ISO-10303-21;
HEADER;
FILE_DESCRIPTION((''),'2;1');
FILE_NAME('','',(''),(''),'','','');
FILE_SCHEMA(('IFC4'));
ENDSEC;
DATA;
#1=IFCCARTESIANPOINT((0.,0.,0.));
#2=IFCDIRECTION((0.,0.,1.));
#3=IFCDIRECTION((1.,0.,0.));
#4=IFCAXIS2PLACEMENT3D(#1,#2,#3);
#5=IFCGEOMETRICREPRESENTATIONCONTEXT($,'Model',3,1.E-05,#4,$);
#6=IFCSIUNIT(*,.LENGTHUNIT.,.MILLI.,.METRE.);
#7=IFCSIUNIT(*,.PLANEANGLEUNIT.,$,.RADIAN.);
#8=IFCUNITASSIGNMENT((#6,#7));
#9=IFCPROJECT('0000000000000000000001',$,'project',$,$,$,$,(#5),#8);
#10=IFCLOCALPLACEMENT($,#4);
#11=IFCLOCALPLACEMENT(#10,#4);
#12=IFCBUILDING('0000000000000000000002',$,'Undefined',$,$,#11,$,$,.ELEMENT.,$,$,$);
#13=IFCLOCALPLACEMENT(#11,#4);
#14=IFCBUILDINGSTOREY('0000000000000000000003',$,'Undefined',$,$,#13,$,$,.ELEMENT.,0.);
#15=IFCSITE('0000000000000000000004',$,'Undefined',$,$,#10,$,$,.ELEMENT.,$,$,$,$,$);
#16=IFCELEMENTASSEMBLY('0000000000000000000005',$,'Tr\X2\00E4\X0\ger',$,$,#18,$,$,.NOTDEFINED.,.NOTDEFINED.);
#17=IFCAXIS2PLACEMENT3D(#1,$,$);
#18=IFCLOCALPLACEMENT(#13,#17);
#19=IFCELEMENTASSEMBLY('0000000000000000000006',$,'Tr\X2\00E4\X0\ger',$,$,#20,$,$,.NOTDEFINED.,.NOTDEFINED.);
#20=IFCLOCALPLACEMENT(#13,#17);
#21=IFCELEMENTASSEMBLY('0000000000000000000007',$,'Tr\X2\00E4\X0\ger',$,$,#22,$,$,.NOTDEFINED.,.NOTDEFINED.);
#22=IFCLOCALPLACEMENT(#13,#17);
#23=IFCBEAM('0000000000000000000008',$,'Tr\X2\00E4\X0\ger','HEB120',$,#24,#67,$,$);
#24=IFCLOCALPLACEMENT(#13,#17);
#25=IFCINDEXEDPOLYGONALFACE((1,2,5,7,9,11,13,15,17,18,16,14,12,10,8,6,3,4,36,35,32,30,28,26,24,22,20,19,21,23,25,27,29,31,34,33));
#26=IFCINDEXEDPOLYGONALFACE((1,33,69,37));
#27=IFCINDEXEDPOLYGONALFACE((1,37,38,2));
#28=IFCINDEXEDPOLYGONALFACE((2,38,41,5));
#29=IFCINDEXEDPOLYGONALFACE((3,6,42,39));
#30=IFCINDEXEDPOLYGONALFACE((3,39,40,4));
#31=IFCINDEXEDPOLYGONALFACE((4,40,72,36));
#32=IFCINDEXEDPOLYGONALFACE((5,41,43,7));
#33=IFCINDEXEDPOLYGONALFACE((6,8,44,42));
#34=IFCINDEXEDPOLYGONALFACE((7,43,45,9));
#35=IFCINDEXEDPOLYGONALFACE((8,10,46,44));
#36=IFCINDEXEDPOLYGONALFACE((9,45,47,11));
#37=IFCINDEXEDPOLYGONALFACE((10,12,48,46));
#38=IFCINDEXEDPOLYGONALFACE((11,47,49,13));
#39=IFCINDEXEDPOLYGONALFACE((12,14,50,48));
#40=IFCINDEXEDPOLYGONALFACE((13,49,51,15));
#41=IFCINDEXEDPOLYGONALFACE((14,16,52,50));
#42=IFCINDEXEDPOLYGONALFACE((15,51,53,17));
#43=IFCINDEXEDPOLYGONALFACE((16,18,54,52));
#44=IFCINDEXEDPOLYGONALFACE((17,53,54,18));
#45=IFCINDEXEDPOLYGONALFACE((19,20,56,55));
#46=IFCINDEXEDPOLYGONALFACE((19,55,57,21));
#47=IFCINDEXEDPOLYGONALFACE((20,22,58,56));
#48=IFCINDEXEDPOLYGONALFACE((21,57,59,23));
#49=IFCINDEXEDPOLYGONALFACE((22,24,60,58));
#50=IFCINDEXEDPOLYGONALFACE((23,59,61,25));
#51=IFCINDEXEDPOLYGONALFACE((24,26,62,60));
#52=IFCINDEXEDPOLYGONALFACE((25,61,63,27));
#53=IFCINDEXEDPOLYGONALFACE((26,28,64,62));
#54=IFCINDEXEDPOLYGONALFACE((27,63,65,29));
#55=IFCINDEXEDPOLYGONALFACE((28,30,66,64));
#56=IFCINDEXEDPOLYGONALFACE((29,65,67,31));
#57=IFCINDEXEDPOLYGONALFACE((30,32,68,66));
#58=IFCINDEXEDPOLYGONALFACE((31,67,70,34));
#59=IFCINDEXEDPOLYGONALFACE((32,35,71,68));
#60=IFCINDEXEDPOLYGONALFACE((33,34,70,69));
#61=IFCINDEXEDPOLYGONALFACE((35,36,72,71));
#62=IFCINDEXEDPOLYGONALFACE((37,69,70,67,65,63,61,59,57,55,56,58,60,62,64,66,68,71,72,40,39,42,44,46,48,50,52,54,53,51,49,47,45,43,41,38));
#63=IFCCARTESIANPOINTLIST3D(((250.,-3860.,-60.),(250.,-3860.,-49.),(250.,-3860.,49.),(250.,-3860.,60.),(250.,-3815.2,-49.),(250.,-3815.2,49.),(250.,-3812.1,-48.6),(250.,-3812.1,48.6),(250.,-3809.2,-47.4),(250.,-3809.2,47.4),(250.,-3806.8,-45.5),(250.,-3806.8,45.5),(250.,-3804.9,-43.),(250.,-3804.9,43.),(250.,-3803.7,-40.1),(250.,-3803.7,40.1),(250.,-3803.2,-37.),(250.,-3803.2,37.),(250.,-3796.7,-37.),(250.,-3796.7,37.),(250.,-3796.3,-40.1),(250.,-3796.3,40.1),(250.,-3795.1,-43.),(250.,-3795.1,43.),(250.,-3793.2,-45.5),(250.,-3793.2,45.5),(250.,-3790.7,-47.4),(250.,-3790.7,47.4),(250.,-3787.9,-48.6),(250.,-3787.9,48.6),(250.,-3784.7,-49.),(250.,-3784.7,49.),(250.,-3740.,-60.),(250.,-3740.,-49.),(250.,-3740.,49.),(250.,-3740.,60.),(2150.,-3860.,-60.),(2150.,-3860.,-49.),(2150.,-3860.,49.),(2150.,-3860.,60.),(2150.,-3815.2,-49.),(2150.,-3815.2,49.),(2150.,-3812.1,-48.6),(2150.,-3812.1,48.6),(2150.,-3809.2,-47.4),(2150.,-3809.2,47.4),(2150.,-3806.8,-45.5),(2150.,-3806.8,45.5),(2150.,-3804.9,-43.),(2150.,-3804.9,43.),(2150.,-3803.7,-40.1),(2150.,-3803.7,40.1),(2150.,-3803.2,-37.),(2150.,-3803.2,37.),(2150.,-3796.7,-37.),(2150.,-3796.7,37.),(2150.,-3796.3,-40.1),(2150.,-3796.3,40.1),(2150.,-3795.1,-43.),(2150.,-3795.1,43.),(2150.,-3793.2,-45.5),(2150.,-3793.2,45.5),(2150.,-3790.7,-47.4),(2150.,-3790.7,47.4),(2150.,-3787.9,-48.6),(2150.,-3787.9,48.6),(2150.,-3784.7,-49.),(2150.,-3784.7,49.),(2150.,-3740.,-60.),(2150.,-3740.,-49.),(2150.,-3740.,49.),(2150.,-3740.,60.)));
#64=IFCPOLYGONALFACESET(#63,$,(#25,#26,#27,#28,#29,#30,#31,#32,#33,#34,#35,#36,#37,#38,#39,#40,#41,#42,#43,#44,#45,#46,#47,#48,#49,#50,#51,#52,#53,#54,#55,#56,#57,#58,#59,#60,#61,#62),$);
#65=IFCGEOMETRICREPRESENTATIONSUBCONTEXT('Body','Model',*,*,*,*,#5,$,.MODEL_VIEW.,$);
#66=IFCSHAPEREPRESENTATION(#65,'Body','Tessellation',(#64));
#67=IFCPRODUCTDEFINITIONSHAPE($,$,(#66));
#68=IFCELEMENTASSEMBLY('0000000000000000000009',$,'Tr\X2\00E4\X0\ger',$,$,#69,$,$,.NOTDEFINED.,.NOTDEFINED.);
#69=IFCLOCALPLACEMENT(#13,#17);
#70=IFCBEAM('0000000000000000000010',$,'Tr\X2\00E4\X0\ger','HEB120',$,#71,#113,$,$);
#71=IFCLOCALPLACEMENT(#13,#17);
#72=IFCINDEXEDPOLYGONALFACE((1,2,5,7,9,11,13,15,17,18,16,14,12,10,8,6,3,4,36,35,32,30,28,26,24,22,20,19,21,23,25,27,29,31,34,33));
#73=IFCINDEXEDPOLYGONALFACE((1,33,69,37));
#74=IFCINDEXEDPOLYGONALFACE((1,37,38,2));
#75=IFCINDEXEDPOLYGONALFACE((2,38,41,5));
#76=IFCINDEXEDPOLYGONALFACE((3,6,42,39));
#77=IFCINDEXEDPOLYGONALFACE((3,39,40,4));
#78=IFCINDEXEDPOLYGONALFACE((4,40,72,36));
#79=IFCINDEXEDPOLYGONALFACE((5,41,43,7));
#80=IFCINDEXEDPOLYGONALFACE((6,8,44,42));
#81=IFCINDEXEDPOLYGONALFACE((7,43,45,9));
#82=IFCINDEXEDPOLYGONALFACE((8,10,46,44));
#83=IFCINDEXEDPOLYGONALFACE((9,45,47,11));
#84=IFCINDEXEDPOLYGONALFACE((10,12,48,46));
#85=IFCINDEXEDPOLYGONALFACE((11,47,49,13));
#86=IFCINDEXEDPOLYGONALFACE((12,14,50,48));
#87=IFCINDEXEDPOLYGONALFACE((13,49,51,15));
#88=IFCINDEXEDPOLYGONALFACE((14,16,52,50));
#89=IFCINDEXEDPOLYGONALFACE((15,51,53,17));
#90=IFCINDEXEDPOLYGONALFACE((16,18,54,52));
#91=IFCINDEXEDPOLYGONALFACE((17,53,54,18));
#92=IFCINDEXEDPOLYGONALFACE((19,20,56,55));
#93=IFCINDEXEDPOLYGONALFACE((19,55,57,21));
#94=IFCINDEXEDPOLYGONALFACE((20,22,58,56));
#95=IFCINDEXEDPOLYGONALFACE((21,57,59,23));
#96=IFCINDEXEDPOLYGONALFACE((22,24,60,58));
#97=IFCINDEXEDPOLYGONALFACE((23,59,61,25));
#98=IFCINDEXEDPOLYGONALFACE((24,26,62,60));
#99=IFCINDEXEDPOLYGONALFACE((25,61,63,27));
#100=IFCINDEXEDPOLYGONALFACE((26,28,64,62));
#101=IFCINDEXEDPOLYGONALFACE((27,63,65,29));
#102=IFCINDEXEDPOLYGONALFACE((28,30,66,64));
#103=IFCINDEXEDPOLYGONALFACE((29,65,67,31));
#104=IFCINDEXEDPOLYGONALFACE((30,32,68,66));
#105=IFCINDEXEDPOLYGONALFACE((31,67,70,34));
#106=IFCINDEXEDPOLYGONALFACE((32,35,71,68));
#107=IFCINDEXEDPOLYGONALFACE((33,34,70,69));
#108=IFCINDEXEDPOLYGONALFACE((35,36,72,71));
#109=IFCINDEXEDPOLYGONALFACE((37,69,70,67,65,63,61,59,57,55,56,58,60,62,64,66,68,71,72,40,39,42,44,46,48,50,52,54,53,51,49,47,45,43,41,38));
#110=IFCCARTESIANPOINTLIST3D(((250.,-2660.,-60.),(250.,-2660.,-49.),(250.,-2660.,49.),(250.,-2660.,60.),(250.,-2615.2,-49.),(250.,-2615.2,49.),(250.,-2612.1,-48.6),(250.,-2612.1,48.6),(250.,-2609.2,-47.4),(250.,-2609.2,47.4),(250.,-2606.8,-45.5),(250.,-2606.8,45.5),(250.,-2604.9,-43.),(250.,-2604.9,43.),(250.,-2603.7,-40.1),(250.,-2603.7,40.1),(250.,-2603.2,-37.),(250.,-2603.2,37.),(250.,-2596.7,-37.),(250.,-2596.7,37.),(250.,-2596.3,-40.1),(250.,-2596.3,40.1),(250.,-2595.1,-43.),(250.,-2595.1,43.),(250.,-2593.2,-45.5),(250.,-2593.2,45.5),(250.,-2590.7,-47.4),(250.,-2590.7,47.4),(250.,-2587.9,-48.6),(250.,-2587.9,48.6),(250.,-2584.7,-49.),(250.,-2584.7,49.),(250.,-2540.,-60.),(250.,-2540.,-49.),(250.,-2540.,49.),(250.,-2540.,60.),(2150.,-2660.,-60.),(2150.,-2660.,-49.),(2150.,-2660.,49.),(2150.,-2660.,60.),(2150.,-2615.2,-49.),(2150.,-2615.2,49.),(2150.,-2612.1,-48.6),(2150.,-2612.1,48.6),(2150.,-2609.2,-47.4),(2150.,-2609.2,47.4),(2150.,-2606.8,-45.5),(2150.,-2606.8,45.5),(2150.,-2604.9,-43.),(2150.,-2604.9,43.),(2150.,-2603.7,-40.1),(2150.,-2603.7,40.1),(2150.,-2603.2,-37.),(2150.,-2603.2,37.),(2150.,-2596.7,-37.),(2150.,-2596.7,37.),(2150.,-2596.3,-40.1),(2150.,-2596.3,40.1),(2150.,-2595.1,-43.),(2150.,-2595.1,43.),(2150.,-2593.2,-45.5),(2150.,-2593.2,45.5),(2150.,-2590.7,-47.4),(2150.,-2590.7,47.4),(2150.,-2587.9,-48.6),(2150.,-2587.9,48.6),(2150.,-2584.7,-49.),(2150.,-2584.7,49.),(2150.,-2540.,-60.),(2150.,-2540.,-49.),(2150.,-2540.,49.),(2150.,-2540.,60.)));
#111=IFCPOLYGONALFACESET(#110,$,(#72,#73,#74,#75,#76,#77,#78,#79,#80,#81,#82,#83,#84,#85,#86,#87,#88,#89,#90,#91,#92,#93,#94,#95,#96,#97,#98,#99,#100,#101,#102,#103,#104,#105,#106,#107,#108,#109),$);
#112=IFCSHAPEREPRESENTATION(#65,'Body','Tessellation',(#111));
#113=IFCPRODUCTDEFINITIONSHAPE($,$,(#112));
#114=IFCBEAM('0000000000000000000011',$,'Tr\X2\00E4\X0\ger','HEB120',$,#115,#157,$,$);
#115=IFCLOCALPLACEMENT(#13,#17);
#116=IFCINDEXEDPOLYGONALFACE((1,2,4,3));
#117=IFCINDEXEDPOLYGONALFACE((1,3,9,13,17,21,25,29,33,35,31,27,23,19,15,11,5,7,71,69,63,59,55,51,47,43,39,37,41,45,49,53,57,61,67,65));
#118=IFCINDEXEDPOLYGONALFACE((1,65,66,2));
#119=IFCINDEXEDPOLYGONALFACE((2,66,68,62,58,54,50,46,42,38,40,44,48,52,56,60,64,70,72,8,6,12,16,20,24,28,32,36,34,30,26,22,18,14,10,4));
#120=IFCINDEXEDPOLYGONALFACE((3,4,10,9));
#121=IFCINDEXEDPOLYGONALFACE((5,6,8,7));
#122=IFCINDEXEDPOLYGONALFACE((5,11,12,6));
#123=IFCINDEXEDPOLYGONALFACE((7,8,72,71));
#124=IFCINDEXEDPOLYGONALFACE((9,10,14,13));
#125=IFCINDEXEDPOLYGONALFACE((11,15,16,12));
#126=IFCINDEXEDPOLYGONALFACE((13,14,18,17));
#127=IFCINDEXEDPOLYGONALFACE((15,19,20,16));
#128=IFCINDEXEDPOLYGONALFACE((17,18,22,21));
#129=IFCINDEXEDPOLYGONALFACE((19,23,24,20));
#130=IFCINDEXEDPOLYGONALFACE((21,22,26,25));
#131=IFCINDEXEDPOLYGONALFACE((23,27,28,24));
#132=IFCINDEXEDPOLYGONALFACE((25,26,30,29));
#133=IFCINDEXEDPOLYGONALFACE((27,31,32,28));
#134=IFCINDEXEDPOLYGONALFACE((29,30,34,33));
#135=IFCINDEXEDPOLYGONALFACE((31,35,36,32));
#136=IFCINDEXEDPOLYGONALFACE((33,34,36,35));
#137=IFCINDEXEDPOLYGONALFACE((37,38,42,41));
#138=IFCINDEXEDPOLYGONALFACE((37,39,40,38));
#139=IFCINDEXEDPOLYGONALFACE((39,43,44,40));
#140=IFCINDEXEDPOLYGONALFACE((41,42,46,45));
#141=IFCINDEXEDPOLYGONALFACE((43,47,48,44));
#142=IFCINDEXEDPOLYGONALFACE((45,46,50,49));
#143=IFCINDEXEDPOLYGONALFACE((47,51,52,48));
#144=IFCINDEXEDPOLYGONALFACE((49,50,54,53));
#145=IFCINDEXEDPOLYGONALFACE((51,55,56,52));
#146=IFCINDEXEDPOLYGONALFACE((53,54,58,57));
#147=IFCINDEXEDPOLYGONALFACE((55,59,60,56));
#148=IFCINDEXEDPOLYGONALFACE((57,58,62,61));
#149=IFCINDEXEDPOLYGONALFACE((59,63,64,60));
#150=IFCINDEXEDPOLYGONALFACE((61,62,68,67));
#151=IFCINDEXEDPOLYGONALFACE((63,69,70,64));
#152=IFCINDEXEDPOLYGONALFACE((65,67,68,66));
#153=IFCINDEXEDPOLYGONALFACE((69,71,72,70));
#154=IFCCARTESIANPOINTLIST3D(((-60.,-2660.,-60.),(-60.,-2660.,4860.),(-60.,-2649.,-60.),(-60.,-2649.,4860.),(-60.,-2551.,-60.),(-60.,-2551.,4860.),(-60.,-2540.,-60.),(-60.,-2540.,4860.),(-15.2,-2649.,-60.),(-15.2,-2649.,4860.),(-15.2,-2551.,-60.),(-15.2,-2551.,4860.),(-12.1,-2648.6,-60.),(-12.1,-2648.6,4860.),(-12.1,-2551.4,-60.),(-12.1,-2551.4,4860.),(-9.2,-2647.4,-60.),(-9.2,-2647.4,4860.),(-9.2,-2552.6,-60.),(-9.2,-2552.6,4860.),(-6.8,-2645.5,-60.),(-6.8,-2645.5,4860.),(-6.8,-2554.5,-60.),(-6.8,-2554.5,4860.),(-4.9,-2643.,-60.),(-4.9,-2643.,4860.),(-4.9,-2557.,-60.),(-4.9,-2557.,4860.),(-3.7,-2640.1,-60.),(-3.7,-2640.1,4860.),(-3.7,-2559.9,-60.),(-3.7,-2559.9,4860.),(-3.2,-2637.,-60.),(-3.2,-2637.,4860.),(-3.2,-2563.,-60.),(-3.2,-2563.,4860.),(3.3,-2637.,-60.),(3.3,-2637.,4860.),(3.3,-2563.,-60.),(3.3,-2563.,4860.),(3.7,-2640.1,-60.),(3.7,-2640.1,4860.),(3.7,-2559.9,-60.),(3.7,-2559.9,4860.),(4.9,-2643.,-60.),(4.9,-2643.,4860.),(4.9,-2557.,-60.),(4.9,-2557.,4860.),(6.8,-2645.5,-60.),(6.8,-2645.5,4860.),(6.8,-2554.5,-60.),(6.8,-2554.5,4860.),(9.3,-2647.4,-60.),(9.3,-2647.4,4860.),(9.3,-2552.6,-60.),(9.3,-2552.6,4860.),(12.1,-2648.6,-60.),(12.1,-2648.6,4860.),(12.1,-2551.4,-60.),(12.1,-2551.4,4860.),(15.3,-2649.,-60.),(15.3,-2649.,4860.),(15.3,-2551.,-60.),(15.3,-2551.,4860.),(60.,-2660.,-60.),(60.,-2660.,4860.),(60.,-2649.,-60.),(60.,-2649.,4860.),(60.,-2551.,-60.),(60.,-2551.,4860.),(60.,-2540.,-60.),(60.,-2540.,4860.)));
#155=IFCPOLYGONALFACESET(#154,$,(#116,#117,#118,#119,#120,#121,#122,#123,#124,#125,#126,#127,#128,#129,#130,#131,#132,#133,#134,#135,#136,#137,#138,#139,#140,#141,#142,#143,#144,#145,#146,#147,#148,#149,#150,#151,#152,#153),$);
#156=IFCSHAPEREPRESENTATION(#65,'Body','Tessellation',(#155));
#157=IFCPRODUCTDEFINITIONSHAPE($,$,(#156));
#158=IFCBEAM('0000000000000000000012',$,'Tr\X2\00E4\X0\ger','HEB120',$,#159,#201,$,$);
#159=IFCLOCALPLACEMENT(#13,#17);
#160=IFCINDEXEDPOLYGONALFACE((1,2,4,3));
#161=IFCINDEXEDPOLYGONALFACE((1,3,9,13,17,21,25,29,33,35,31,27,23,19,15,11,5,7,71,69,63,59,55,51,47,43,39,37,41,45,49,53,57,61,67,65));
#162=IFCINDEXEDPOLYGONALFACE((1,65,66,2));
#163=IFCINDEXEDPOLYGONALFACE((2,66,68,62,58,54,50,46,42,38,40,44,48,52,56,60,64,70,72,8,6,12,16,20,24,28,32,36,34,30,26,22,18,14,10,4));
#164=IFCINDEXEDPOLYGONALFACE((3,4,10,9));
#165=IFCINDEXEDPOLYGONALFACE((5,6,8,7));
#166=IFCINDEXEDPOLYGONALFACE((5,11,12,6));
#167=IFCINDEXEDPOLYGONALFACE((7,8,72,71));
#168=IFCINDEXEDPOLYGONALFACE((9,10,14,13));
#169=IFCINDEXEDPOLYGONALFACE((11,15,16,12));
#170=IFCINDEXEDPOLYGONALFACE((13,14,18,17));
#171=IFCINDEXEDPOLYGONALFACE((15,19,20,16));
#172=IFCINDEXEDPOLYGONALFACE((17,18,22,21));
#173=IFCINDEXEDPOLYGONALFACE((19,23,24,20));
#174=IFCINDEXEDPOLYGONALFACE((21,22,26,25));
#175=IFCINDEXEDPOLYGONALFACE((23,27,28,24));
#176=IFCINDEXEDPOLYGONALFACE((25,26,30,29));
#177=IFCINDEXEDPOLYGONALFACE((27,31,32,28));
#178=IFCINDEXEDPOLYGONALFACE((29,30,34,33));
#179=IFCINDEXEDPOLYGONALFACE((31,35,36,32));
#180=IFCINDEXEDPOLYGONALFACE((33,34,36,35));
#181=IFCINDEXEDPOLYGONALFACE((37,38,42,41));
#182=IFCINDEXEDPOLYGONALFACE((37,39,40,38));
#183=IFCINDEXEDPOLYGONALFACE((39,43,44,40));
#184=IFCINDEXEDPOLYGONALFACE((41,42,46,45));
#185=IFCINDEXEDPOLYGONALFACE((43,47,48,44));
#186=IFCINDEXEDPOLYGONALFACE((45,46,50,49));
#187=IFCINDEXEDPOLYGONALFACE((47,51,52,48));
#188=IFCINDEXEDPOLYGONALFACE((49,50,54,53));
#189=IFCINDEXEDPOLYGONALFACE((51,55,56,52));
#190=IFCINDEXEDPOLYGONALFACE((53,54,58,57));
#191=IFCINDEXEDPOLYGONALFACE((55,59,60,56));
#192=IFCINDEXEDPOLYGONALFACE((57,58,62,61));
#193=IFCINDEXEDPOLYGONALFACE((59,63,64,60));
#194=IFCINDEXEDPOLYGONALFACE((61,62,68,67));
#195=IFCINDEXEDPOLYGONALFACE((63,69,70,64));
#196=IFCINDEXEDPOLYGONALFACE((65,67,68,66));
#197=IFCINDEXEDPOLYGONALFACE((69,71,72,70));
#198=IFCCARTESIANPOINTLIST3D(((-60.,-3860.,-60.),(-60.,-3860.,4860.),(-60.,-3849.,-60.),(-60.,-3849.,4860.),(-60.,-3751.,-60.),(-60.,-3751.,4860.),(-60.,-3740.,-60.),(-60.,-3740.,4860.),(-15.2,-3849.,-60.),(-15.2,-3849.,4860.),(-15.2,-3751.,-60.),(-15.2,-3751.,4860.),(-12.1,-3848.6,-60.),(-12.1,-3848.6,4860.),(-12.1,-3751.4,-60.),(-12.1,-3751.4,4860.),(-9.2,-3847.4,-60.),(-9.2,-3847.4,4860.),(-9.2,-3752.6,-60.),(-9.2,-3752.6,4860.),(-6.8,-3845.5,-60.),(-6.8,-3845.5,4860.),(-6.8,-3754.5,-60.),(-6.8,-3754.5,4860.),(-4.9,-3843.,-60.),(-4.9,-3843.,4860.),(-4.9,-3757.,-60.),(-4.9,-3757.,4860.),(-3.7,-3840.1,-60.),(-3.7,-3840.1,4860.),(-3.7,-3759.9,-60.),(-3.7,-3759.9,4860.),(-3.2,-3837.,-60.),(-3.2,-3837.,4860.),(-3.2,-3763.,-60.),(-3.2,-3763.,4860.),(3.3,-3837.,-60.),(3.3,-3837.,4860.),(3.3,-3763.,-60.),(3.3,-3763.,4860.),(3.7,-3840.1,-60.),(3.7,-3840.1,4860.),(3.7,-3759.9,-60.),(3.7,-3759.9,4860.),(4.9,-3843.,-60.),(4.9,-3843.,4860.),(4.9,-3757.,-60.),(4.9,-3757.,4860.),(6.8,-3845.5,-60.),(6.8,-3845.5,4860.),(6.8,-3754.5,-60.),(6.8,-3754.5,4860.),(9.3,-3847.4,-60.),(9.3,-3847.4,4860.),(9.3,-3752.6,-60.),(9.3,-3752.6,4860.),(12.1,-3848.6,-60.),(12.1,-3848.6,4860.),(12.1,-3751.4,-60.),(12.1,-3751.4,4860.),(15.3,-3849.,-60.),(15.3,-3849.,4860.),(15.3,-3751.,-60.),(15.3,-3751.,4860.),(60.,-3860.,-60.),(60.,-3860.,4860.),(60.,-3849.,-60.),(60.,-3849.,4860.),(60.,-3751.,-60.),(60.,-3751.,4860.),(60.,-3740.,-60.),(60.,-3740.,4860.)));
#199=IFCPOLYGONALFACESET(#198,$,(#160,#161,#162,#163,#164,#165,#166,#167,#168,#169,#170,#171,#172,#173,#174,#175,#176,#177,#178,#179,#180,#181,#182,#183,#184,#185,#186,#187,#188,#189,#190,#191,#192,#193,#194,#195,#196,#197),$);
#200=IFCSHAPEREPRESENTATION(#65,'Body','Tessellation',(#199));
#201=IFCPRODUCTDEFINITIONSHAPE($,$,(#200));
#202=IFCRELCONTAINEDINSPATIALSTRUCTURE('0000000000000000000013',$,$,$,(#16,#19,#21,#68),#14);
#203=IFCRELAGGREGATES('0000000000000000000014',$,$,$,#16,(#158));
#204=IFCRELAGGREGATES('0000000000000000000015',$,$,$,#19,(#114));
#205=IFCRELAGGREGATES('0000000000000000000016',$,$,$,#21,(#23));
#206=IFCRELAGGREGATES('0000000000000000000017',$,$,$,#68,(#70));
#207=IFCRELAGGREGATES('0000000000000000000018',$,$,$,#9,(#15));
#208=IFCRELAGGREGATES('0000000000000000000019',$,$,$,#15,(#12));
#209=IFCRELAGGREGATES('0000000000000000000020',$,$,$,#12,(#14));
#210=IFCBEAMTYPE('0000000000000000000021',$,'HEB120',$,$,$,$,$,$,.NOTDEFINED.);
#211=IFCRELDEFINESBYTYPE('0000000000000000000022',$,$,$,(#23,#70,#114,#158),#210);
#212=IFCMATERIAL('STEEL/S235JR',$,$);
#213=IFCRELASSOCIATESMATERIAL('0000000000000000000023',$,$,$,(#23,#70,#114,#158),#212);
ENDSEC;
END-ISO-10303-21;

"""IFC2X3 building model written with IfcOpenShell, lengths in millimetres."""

from ifc_helpers import new_model, si_unit, frame, origin_with_axes, origin_2d_with_axis, place, context, subcontext, project, spatial, i_section, extrude, clip, halfspace, material, type_object, element, aggregate, save


model = new_model("IFC2X3")

# Units and contexts
model_context = context("Model", 3, precision=1e-05, world=origin_with_axes())
body_context = subcontext(model_context, "Body", "Model", "MODEL_VIEW")
ifc_project = project(units=[si_unit("LENGTHUNIT", "METRE", prefix="MILLI"), si_unit("PLANEANGLEUNIT", "RADIAN")], contexts=[model_context])

# Site, building, storey
site_placement = place(None, origin_with_axes())
site = spatial("IfcSite", under=ifc_project, at=site_placement, Name="Undefined", CompositionType="ELEMENT")
building_placement = place(site_placement, origin_with_axes())
building = spatial("IfcBuilding", under=site, at=building_placement, Name="Undefined", CompositionType="ELEMENT")
storey_placement = place(building_placement, origin_with_axes())
storey = spatial("IfcBuildingStorey", under=building, at=storey_placement, Name="Undefined", CompositionType="ELEMENT", Elevation=0.0)

# Element assemblies, beams
assembly_1_placement = place(storey_placement, origin_with_axes())
assembly_1 = element("IfcElementAssembly", 1, at=assembly_1_placement, inside=storey, Name="Träger", AssemblyPlace="NOTDEFINED", PredefinedType="NOTDEFINED")
ifc_material_1 = material(Name="STEEL/S235JR")
beam_type = type_object("IfcBeamType", Name="HEB120", PredefinedType="NOTDEFINED")
assembly_2_placement = place(storey_placement, origin_with_axes())
assembly_2 = element("IfcElementAssembly", 2, at=assembly_2_placement, inside=storey, Name="Träger", AssemblyPlace="NOTDEFINED", PredefinedType="NOTDEFINED")
assembly_3_placement = place(storey_placement, origin_with_axes())
assembly_3 = element("IfcElementAssembly", 3, at=assembly_3_placement, inside=storey, Name="Träger", AssemblyPlace="NOTDEFINED", PredefinedType="NOTDEFINED")
beam_1_placement = place(assembly_3_placement, frame((250.0, -3800.0, 0.0), z_axis=(0.0, 0.0, 1.0), x_axis=(1.0, 0.0, 0.0)))
beam_1 = element("IfcBeam", 4, at=beam_1_placement, type_object=beam_type, material=ifc_material_1, Name="Träger", Description="HEB120", context=body_context, shape_type="Clipping", body=[
    clip(clip(extrude(i_section(OverallWidth=120.0, OverallDepth=120.0, WebThickness=6.5, FlangeThickness=11.0, FilletRadius=12.0, at=origin_2d_with_axis()), frame((1910.0, 0.0, 0.0), z_axis=(-1.0, 0.0, 0.0), x_axis=(0.0, -1.0, 0.0)), (0.0, 0.0, 1.0), 1910.0), halfspace(frame((1900.0, 0.0, -60.0), z_axis=(-1.0, 0.0, 0.0), x_axis=(0.0, 1.0, 0.0)), True)), halfspace(frame((0.0, 0.0, -60.0), z_axis=(1.0, 0.0, 0.0), x_axis=(0.0, -1.0, 0.0)), True)),
])
assembly_4_placement = place(storey_placement, origin_with_axes())
assembly_4 = element("IfcElementAssembly", 5, at=assembly_4_placement, inside=storey, Name="Träger", AssemblyPlace="NOTDEFINED", PredefinedType="NOTDEFINED")
beam_2_placement = place(assembly_4_placement, frame((250.0, -2600.0, 0.0), z_axis=(0.0, 0.0, 1.0), x_axis=(1.0, 0.0, 0.0)))
beam_2 = element("IfcBeam", 6, at=beam_2_placement, type_object=beam_type, material=ifc_material_1, Name="Träger", Description="HEB120", context=body_context, shape_type="Clipping", body=[
    clip(clip(extrude(i_section(OverallWidth=120.0, OverallDepth=120.0, WebThickness=6.5, FlangeThickness=11.0, FilletRadius=12.0, at=origin_2d_with_axis()), frame((1910.0, 0.0, 0.0), z_axis=(-1.0, 0.0, 0.0), x_axis=(0.0, -1.0, 0.0)), (0.0, 0.0, 1.0), 1910.0), halfspace(frame((1900.0, 0.0, -60.0), z_axis=(-1.0, 0.0, 0.0), x_axis=(0.0, 1.0, 0.0)), True)), halfspace(frame((0.0, 0.0, -60.0), z_axis=(1.0, 0.0, 0.0), x_axis=(0.0, -1.0, 0.0)), True)),
])

# Beams
beam_3_placement = place(assembly_2_placement, frame((0.0, -2600.0, -60.0), z_axis=(0.0, 1.0, 0.0), x_axis=(0.0, 0.0, 1.0)))
beam_3 = element("IfcBeam", 7, at=beam_3_placement, type_object=beam_type, material=ifc_material_1, Name="Träger", Description="HEB120", context=body_context, shape_type="SweptSolid", body=[
    extrude(i_section(OverallWidth=120.0, OverallDepth=120.0, WebThickness=6.5, FlangeThickness=11.0, FilletRadius=12.0, at=origin_2d_with_axis()), frame((4920.0, 0.0, 0.0), z_axis=(-1.0, 0.0, 0.0), x_axis=(0.0, -1.0, 0.0)), (0.0, 0.0, 1.0), 4920.0),
])
beam_4_placement = place(assembly_1_placement, frame((0.0, -3800.0, -60.0), z_axis=(0.0, 1.0, 0.0), x_axis=(0.0, 0.0, 1.0)))
beam_4 = element("IfcBeam", 8, at=beam_4_placement, type_object=beam_type, material=ifc_material_1, Name="Träger", Description="HEB120", context=body_context, shape_type="SweptSolid", body=[
    extrude(i_section(OverallWidth=120.0, OverallDepth=120.0, WebThickness=6.5, FlangeThickness=11.0, FilletRadius=12.0, at=origin_2d_with_axis()), frame((4920.0, 0.0, 0.0), z_axis=(-1.0, 0.0, 0.0), x_axis=(0.0, -1.0, 0.0)), (0.0, 0.0, 1.0), 4920.0),
])

aggregate(assembly_1, [beam_4])
aggregate(assembly_2, [beam_3])

aggregate(assembly_3, [beam_1])
aggregate(assembly_4, [beam_2])

save(model, "model.ifc")
